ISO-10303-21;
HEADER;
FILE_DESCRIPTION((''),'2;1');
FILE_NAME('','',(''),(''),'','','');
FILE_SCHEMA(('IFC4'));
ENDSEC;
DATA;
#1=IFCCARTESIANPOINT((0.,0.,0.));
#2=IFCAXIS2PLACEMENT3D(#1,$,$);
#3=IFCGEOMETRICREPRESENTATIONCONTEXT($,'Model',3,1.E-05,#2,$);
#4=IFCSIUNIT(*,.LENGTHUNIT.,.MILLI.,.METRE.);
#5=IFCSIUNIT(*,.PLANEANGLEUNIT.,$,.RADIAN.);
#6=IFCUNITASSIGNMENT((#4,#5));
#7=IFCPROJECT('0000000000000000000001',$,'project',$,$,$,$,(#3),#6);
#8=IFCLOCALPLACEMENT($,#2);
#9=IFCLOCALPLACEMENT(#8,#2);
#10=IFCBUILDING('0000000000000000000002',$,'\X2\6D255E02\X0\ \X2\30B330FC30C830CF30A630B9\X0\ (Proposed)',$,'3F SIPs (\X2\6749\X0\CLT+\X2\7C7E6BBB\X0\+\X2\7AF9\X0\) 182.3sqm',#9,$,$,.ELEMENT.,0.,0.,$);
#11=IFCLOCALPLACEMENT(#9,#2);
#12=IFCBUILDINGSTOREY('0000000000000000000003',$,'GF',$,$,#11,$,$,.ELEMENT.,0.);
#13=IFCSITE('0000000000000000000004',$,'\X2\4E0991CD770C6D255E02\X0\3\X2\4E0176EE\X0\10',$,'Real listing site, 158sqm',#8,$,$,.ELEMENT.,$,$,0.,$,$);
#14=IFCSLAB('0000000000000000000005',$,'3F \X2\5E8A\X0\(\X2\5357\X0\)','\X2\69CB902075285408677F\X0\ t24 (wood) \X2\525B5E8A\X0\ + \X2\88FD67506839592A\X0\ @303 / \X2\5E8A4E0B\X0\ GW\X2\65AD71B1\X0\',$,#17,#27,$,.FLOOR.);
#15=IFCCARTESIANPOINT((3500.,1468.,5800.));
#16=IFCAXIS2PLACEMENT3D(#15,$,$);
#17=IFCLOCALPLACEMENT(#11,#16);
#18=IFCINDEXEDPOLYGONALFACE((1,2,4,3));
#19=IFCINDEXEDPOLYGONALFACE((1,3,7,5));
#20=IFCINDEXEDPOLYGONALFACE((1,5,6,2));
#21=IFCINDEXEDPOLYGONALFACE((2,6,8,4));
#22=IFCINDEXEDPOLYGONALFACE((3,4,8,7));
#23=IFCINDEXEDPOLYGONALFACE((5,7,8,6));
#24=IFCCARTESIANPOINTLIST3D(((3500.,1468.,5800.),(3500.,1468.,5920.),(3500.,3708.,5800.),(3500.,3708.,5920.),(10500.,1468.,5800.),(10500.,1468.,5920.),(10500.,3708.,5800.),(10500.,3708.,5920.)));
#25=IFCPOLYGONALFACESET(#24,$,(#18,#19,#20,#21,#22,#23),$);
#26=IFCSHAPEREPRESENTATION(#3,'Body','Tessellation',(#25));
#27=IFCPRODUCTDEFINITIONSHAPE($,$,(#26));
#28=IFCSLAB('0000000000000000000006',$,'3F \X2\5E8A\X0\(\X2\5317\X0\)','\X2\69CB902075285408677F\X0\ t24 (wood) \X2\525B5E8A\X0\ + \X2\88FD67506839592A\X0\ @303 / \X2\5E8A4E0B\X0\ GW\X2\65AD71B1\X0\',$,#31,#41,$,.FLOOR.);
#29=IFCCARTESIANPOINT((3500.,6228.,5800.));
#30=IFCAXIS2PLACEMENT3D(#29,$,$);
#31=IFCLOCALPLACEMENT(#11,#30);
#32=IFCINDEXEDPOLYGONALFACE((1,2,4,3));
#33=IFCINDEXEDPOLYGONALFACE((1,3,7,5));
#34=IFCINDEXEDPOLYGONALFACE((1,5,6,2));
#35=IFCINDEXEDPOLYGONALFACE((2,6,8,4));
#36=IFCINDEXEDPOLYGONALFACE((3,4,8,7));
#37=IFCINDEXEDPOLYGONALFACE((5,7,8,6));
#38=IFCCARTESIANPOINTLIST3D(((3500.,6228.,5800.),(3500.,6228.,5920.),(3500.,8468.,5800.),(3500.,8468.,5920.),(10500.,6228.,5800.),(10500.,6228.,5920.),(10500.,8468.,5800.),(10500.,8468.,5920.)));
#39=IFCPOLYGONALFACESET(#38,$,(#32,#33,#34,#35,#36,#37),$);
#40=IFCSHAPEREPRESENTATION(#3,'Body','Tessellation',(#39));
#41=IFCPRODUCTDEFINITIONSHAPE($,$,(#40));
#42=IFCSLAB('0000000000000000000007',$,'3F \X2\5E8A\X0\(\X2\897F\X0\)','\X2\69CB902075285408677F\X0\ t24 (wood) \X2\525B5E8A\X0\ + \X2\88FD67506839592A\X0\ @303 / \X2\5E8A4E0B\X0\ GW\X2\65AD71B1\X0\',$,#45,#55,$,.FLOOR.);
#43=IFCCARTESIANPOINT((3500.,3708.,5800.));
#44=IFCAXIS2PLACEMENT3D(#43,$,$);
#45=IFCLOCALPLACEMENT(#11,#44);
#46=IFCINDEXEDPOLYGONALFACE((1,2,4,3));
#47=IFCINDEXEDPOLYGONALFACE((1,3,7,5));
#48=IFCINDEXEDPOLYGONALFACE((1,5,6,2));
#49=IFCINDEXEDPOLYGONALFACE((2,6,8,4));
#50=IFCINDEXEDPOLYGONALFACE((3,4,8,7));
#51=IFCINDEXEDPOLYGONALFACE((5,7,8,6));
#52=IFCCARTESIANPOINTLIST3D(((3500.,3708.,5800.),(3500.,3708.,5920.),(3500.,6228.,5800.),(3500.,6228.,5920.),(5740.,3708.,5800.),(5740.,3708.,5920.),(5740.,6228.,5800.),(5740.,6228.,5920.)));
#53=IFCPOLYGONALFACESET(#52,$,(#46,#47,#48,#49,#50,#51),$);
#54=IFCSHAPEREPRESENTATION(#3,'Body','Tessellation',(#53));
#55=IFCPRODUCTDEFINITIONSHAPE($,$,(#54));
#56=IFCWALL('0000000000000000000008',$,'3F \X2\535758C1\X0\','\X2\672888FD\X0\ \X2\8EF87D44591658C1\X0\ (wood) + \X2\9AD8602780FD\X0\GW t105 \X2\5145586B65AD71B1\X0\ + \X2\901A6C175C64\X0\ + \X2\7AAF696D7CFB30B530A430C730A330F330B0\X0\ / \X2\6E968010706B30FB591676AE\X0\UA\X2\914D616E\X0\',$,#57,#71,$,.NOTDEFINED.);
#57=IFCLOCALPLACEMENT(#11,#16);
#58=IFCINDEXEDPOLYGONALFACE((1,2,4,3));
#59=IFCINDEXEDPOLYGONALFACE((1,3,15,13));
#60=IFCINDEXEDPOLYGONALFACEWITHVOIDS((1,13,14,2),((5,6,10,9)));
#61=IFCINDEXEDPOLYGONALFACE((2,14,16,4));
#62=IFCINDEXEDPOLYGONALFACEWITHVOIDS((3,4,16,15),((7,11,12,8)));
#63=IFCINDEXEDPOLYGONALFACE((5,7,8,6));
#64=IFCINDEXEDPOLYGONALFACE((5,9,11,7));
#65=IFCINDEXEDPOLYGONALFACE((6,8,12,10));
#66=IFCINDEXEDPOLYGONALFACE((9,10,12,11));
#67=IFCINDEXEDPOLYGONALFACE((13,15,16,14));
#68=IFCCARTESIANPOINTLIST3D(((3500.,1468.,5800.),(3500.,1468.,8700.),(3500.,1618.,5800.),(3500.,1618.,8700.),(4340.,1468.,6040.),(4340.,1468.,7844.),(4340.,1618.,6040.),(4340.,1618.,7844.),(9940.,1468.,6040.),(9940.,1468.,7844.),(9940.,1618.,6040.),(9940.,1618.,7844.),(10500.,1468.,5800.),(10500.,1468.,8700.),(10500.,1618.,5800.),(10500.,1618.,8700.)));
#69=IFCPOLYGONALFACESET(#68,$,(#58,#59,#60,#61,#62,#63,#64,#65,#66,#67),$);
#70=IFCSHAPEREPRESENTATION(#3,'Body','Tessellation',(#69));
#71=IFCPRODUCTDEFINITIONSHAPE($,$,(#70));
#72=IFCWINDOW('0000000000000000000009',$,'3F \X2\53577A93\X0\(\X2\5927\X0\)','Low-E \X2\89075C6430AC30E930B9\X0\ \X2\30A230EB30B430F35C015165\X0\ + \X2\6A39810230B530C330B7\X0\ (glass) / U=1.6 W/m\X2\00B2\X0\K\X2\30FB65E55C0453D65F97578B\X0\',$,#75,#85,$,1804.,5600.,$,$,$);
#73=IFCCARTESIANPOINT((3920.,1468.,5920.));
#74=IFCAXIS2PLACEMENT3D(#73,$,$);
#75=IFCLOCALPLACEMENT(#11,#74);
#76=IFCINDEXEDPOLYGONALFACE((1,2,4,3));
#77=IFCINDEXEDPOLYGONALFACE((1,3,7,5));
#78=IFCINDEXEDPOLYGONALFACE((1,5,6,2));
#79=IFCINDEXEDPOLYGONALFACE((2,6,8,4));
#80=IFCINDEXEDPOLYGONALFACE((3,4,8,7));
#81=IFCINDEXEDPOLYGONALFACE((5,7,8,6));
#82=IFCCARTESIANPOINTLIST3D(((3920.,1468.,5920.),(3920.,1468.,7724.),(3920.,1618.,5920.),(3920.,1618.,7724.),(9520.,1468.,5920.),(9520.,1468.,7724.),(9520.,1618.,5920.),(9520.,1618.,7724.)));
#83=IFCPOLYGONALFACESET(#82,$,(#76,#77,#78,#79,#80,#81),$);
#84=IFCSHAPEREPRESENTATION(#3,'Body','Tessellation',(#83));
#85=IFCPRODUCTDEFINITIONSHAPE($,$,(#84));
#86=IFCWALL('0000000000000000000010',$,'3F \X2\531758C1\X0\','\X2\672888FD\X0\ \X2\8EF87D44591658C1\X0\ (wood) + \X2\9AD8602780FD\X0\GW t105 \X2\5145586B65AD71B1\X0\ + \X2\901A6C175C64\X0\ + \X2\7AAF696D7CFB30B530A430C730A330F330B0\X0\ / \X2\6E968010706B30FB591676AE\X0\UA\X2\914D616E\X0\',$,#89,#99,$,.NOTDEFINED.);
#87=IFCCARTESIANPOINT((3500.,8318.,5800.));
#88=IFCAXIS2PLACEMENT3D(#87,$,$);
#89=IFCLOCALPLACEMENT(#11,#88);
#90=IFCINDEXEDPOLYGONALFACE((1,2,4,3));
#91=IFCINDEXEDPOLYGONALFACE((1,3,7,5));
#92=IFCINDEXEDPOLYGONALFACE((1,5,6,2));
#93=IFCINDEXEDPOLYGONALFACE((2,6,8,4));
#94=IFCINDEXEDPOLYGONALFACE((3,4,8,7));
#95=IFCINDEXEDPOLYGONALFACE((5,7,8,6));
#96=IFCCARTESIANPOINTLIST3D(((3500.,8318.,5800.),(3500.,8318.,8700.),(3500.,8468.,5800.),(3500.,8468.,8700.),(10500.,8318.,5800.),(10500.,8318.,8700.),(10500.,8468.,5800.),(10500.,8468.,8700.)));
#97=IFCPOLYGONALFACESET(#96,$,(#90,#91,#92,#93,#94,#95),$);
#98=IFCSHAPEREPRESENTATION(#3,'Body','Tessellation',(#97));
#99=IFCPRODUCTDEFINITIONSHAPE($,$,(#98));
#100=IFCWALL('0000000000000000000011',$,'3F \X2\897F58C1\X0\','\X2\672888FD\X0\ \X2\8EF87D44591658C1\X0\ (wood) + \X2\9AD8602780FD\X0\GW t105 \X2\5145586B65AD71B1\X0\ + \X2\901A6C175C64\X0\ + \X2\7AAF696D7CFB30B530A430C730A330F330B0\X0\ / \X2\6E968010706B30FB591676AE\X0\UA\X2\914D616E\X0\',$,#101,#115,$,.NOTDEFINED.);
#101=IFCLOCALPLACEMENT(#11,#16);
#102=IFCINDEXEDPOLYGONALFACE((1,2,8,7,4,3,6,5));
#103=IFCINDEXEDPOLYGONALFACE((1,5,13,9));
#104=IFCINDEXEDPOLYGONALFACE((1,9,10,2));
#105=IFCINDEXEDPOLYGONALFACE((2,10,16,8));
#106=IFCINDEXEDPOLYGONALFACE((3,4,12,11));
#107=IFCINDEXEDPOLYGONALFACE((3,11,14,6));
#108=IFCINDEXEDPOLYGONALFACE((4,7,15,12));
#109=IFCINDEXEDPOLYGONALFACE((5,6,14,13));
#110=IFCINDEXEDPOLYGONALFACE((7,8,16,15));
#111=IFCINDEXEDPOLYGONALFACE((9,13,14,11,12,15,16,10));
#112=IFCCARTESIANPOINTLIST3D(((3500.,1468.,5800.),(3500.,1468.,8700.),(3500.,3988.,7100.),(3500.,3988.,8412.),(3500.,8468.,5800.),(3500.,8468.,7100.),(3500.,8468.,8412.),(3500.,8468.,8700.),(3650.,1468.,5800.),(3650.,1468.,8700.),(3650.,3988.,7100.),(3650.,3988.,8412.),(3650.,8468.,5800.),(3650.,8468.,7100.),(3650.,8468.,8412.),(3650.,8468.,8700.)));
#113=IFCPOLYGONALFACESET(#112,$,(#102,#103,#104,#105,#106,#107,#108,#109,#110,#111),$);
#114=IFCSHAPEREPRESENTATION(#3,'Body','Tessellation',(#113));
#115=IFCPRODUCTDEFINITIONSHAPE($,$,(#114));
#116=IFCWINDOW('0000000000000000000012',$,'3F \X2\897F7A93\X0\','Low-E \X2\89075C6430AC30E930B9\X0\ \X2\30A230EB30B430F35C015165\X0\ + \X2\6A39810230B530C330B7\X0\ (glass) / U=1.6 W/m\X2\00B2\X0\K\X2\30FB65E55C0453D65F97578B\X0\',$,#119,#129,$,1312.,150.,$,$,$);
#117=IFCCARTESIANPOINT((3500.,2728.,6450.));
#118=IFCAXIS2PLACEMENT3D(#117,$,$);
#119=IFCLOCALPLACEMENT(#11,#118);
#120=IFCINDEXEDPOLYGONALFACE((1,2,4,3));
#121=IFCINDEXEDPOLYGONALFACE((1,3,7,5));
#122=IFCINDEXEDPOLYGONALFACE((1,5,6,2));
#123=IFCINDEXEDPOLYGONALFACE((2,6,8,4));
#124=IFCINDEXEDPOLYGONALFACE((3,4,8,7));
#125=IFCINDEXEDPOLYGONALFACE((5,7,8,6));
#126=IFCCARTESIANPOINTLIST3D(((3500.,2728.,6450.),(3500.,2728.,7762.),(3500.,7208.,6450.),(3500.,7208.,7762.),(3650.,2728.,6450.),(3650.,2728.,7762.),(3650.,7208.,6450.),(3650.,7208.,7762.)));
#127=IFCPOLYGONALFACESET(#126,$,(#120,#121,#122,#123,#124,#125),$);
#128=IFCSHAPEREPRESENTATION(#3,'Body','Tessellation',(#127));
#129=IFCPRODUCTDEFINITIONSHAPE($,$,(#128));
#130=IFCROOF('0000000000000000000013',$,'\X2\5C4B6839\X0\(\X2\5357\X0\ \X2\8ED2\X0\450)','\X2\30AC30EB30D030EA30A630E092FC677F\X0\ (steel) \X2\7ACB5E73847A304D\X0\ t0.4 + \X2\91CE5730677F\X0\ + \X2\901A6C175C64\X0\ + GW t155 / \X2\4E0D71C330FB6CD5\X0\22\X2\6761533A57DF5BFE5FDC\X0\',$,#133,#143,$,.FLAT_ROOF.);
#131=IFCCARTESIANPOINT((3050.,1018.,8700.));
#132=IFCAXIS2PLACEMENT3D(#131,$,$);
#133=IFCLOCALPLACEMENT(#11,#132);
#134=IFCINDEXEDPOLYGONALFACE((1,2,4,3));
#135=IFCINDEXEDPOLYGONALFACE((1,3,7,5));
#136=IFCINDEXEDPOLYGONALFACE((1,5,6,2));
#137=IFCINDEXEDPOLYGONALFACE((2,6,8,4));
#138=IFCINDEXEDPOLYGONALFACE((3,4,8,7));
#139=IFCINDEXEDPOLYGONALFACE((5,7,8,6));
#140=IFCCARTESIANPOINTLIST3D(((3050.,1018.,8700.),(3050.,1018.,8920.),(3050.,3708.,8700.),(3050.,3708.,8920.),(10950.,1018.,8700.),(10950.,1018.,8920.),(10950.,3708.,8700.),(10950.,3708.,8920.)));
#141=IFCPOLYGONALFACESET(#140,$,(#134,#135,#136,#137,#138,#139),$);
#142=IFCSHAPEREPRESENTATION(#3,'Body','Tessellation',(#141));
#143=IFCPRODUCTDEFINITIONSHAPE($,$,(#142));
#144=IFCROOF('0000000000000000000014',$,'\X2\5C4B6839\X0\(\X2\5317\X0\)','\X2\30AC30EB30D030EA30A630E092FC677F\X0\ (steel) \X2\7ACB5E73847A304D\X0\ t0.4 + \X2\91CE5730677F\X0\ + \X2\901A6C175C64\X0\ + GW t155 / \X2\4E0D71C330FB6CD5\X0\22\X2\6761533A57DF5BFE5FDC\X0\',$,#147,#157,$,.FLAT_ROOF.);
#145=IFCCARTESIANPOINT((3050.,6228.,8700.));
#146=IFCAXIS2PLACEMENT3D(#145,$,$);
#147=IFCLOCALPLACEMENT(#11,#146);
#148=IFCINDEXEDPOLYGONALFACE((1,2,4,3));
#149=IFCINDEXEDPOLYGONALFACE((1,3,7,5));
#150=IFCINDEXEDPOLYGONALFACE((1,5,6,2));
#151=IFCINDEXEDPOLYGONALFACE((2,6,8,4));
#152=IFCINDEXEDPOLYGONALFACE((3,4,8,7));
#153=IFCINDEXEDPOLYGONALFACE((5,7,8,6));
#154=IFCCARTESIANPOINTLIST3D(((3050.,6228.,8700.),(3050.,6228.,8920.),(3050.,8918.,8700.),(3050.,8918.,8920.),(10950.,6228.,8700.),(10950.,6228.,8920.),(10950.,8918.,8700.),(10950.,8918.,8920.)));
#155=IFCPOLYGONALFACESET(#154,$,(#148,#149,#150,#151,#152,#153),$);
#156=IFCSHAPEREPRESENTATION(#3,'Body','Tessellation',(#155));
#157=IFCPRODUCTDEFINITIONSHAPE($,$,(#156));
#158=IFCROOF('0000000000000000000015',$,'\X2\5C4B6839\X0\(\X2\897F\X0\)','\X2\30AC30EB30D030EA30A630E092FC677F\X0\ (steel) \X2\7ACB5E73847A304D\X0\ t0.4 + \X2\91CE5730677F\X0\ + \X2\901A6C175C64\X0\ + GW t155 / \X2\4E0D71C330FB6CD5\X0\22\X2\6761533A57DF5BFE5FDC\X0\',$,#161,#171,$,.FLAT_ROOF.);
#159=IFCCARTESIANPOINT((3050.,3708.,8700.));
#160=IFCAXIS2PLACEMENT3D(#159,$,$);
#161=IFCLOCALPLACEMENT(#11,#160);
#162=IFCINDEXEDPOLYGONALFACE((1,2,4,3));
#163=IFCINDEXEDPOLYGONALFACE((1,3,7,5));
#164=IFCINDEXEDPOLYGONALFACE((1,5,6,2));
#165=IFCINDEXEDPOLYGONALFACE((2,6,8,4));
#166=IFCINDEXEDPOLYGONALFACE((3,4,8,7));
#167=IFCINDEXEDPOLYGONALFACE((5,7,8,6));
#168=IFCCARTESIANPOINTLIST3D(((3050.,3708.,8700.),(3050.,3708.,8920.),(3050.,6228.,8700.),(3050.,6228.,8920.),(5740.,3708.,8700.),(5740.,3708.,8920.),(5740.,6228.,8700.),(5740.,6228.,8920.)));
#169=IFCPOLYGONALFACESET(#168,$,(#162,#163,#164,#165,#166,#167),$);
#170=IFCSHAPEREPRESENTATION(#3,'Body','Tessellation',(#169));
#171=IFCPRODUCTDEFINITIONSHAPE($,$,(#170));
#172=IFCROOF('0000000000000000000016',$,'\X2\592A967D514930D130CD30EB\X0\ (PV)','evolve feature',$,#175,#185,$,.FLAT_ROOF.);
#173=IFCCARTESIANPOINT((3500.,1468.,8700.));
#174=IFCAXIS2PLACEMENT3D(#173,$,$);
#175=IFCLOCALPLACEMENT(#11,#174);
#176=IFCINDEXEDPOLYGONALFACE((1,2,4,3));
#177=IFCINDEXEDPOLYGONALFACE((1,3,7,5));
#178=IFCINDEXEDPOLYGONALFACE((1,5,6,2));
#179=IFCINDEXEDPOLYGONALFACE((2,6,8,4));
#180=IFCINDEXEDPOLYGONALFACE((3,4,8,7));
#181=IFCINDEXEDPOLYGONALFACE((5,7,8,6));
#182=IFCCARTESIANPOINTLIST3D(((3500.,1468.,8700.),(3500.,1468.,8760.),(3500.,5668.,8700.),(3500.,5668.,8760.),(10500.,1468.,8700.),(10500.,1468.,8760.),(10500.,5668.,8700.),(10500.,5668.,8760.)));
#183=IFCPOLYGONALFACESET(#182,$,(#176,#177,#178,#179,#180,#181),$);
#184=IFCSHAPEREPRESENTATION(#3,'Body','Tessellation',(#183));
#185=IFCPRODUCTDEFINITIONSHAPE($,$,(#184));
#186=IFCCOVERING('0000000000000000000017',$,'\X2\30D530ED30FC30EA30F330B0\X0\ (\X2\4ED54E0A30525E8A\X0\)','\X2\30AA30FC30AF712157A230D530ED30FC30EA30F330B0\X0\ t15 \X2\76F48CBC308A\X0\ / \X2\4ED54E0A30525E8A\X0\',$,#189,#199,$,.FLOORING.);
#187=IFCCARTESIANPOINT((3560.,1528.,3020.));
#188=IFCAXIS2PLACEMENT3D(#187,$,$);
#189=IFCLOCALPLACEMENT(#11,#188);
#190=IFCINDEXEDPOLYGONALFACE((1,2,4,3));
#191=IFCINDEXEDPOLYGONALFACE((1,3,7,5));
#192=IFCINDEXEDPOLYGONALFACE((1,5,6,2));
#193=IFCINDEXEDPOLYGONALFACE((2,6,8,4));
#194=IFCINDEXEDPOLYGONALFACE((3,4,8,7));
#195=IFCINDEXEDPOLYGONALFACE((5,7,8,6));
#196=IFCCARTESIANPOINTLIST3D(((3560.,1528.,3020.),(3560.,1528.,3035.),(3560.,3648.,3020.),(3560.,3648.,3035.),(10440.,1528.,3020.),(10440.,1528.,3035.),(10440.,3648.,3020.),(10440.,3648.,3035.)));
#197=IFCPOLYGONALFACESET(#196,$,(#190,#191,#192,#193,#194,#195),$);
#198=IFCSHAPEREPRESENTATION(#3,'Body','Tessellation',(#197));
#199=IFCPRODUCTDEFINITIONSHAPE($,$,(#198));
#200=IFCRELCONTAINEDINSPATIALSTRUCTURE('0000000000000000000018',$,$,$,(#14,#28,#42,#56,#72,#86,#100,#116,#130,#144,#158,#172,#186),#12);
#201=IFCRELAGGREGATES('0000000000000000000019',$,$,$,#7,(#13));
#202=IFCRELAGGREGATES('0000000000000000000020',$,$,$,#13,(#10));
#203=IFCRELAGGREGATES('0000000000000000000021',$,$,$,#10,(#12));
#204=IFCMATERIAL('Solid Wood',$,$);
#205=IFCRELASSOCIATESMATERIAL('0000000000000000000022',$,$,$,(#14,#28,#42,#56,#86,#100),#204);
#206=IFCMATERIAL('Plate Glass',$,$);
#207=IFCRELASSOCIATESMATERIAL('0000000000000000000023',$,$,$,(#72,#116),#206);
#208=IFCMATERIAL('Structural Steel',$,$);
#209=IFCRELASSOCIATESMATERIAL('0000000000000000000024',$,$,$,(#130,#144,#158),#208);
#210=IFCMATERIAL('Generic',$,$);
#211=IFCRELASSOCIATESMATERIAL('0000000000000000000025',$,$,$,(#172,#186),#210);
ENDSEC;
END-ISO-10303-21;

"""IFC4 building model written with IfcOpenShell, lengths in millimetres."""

from ifc_helpers import new_model, si_unit, frame, frame_2d, origin, place, context, project, spatial, rectangle, extrude, material, element, fill, save


model = new_model("IFC4")

# Units and contexts
model_context = context("Model", 3, precision=1e-05, world=origin())
ifc_project = project(units=[si_unit("LENGTHUNIT", "METRE", prefix="MILLI"), si_unit("PLANEANGLEUNIT", "RADIAN")], contexts=[model_context])

# Site, building, storey
site_placement = place(None, origin())
site = spatial("IfcSite", under=ifc_project, at=site_placement, Name="三重県津市3丁目10", ObjectType="Real listing site, 158sqm", CompositionType="ELEMENT", RefElevation=0.0)
building_placement = place(site_placement, origin())
building = spatial("IfcBuilding", under=site, at=building_placement, Name="津市 コートハウス (Proposed)", ObjectType="3F SIPs (杉CLT+籾殻+竹) 182.3sqm", CompositionType="ELEMENT", ElevationOfRefHeight=0.0, ElevationOfTerrain=0.0)
storey_placement = place(building_placement, origin())
storey = spatial("IfcBuildingStorey", under=building, at=storey_placement, Name="GF", CompositionType="ELEMENT", Elevation=0.0)

# Slabs
ifc_material_1 = material(Name="Solid Wood")
slab_1_placement = place(storey_placement, frame((3500.0, 1468.0, 5800.0)))
element("IfcSlab", 1, at=slab_1_placement, inside=storey, material=ifc_material_1, Name="3F 床(南)", Description="構造用合板 t24 (wood) 剛床 + 製材根太 @303 / 床下 GW断熱", PredefinedType="FLOOR", context=model_context, shape_type="SweptSolid", body=[
    extrude(rectangle(XDim=7000.0, YDim=2240.0, at=frame_2d((3500.0, 1120.0))), frame((3500.0, 1468.0, 5800.0)), (0.0, 0.0, 1.0), 120.0),
])
slab_2_placement = place(storey_placement, frame((3500.0, 6228.0, 5800.0)))
element("IfcSlab", 2, at=slab_2_placement, inside=storey, material=ifc_material_1, Name="3F 床(北)", Description="構造用合板 t24 (wood) 剛床 + 製材根太 @303 / 床下 GW断熱", PredefinedType="FLOOR", context=model_context, shape_type="SweptSolid", body=[
    extrude(rectangle(XDim=7000.0, YDim=2240.0, at=frame_2d((3500.0, 1120.0))), frame((3500.0, 6228.0, 5800.0)), (0.0, 0.0, 1.0), 120.0),
])
slab_3_placement = place(storey_placement, frame((3500.0, 3708.0, 5800.0)))
element("IfcSlab", 3, at=slab_3_placement, inside=storey, material=ifc_material_1, Name="3F 床(西)", Description="構造用合板 t24 (wood) 剛床 + 製材根太 @303 / 床下 GW断熱", PredefinedType="FLOOR", context=model_context, shape_type="SweptSolid", body=[
    extrude(rectangle(XDim=2240.0, YDim=2520.0, at=frame_2d((1120.0, 1260.0))), frame((3500.0, 3708.0, 5800.0)), (0.0, 0.0, 1.0), 120.0),
])

# Wall, opening, window
wall_1_placement = place(storey_placement, frame((3500.0, 1468.0, 5800.0)))
wall_1 = element("IfcWall", 4, at=wall_1_placement, inside=storey, material=ifc_material_1, Name="3F 南壁", Description="木製 軸組外壁 (wood) + 高性能GW t105 充填断熱 + 通気層 + 窯業系サイディング / 準耐火・外皮UA配慮", PredefinedType="NOTDEFINED", context=model_context, shape_type="SweptSolid", body=[
    extrude(rectangle(XDim=7000.0, YDim=150.0, at=frame_2d((3500.0, 75.0))), frame((3500.0, 1468.0, 5800.0)), (0.0, 0.0, 1.0), 2900.0),
])
opening_1_placement = place(storey_placement, frame((3920.0, 1468.0, 5920.0)))
opening_1 = element("IfcOpeningElement", 5, at=opening_1_placement, cuts=wall_1, PredefinedType="NOTDEFINED", context=model_context, shape_type="SweptSolid", body=[
    extrude(rectangle(XDim=5600.0, YDim=150.0, at=frame_2d((2800.0, 75.0))), frame((3920.0, 1468.0, 5920.0)), (0.0, 0.0, 1.0), 1804.0),
])
ifc_material_2 = material(Name="Plate Glass")
window_1_placement = place(storey_placement, frame((3920.0, 1468.0, 5920.0)))
window_1 = element("IfcWindow", 6, at=window_1_placement, inside=storey, material=ifc_material_2, Name="3F 南窓(大)", Description="Low-E 複層ガラス アルゴン封入 + 樹脂サッシ (glass) / U=1.6 W/m²K・日射取得型", OverallHeight=1804.0, OverallWidth=5600.0, context=model_context, shape_type="SweptSolid", body=[
    extrude(rectangle(XDim=5600.0, YDim=150.0, at=frame_2d((2800.0, 75.0))), frame((3920.0, 1468.0, 5920.0)), (0.0, 0.0, 1.0), 1804.0),
])
fill(opening_1, window_1)

# Wall
wall_2_placement = place(storey_placement, frame((3500.0, 8318.0, 5800.0)))
element("IfcWall", 7, at=wall_2_placement, inside=storey, material=ifc_material_1, Name="3F 北壁", Description="木製 軸組外壁 (wood) + 高性能GW t105 充填断熱 + 通気層 + 窯業系サイディング / 準耐火・外皮UA配慮", PredefinedType="NOTDEFINED", context=model_context, shape_type="SweptSolid", body=[
    extrude(rectangle(XDim=7000.0, YDim=150.0, at=frame_2d((3500.0, 75.0))), frame((3500.0, 8318.0, 5800.0)), (0.0, 0.0, 1.0), 2900.0),
])

# Wall, opening, window
wall_3_placement = place(storey_placement, frame((3500.0, 1468.0, 5800.0)))
wall_3 = element("IfcWall", 8, at=wall_3_placement, inside=storey, material=ifc_material_1, Name="3F 西壁", Description="木製 軸組外壁 (wood) + 高性能GW t105 充填断熱 + 通気層 + 窯業系サイディング / 準耐火・外皮UA配慮", PredefinedType="NOTDEFINED", context=model_context, shape_type="SweptSolid", body=[
    extrude(rectangle(XDim=150.0, YDim=7000.0, at=frame_2d((75.0, 3500.0))), frame((3500.0, 1468.0, 5800.0)), (0.0, 0.0, 1.0), 2900.0),
])
opening_2_placement = place(storey_placement, frame((3500.0, 2728.0, 6450.0)))
opening_2 = element("IfcOpeningElement", 9, at=opening_2_placement, cuts=wall_3, PredefinedType="NOTDEFINED", context=model_context, shape_type="SweptSolid", body=[
    extrude(rectangle(XDim=150.0, YDim=4480.0, at=frame_2d((75.0, 2240.0))), frame((3500.0, 2728.0, 6450.0)), (0.0, 0.0, 1.0), 1312.0),
])
window_2_placement = place(storey_placement, frame((3500.0, 2728.0, 6450.0)))
window_2 = element("IfcWindow", 10, at=window_2_placement, inside=storey, material=ifc_material_2, Name="3F 西窓", Description="Low-E 複層ガラス アルゴン封入 + 樹脂サッシ (glass) / U=1.6 W/m²K・日射取得型", OverallHeight=1312.0, OverallWidth=150.0, context=model_context, shape_type="SweptSolid", body=[
    extrude(rectangle(XDim=150.0, YDim=4480.0, at=frame_2d((75.0, 2240.0))), frame((3500.0, 2728.0, 6450.0)), (0.0, 0.0, 1.0), 1312.0),
])
fill(opening_2, window_2)

# Roofs
ifc_material_3 = material(Name="Structural Steel")
roof_1_placement = place(storey_placement, frame((3050.0, 1018.0, 8700.0)))
element("IfcRoof", 11, at=roof_1_placement, inside=storey, material=ifc_material_3, Name="屋根(南 軒450)", Description="ガルバリウム鋼板 (steel) 立平葺き t0.4 + 野地板 + 通気層 + GW t155 / 不燃・法22条区域対応", PredefinedType="FLAT_ROOF", context=model_context, shape_type="SweptSolid", body=[
    extrude(rectangle(XDim=7900.0, YDim=2690.0, at=frame_2d((3950.0, 1345.0))), frame((3050.0, 1018.0, 8700.0)), (0.0, 0.0, 1.0), 220.0),
])
roof_2_placement = place(storey_placement, frame((3050.0, 6228.0, 8700.0)))
element("IfcRoof", 12, at=roof_2_placement, inside=storey, material=ifc_material_3, Name="屋根(北)", Description="ガルバリウム鋼板 (steel) 立平葺き t0.4 + 野地板 + 通気層 + GW t155 / 不燃・法22条区域対応", PredefinedType="FLAT_ROOF", context=model_context, shape_type="SweptSolid", body=[
    extrude(rectangle(XDim=7900.0, YDim=2690.0, at=frame_2d((3950.0, 1345.0))), frame((3050.0, 6228.0, 8700.0)), (0.0, 0.0, 1.0), 220.0),
])
roof_3_placement = place(storey_placement, frame((3050.0, 3708.0, 8700.0)))
element("IfcRoof", 13, at=roof_3_placement, inside=storey, material=ifc_material_3, Name="屋根(西)", Description="ガルバリウム鋼板 (steel) 立平葺き t0.4 + 野地板 + 通気層 + GW t155 / 不燃・法22条区域対応", PredefinedType="FLAT_ROOF", context=model_context, shape_type="SweptSolid", body=[
    extrude(rectangle(XDim=2690.0, YDim=2520.0, at=frame_2d((1345.0, 1260.0))), frame((3050.0, 3708.0, 8700.0)), (0.0, 0.0, 1.0), 220.0),
])
ifc_material_4 = material(Name="Generic")
roof_4_placement = place(storey_placement, frame((3500.0, 1468.0, 8700.0)))
element("IfcRoof", 14, at=roof_4_placement, inside=storey, material=ifc_material_4, Name="太陽光パネル (PV)", Description="evolve feature", PredefinedType="FLAT_ROOF", context=model_context, shape_type="SweptSolid", body=[
    extrude(rectangle(XDim=7000.0, YDim=4200.0, at=frame_2d((3500.0, 2100.0))), frame((3500.0, 1468.0, 8700.0)), (0.0, 0.0, 1.0), 60.0),
])

# Covering
covering_1_placement = place(storey_placement, frame((3560.0, 1528.0, 3020.0)))
element("IfcCovering", 15, at=covering_1_placement, inside=storey, material=ifc_material_4, Name="フローリング (仕上げ床)", Description="オーク無垢フローリング t15 直貼り / 仕上げ床", PredefinedType="FLOORING", context=model_context, shape_type="SweptSolid", body=[
    extrude(rectangle(XDim=6880.0, YDim=2120.0, at=frame_2d((3440.0, 1060.0))), frame((3560.0, 1528.0, 3020.0)), (0.0, 0.0, 1.0), 15.0),
])

save(model, "model.ifc")
